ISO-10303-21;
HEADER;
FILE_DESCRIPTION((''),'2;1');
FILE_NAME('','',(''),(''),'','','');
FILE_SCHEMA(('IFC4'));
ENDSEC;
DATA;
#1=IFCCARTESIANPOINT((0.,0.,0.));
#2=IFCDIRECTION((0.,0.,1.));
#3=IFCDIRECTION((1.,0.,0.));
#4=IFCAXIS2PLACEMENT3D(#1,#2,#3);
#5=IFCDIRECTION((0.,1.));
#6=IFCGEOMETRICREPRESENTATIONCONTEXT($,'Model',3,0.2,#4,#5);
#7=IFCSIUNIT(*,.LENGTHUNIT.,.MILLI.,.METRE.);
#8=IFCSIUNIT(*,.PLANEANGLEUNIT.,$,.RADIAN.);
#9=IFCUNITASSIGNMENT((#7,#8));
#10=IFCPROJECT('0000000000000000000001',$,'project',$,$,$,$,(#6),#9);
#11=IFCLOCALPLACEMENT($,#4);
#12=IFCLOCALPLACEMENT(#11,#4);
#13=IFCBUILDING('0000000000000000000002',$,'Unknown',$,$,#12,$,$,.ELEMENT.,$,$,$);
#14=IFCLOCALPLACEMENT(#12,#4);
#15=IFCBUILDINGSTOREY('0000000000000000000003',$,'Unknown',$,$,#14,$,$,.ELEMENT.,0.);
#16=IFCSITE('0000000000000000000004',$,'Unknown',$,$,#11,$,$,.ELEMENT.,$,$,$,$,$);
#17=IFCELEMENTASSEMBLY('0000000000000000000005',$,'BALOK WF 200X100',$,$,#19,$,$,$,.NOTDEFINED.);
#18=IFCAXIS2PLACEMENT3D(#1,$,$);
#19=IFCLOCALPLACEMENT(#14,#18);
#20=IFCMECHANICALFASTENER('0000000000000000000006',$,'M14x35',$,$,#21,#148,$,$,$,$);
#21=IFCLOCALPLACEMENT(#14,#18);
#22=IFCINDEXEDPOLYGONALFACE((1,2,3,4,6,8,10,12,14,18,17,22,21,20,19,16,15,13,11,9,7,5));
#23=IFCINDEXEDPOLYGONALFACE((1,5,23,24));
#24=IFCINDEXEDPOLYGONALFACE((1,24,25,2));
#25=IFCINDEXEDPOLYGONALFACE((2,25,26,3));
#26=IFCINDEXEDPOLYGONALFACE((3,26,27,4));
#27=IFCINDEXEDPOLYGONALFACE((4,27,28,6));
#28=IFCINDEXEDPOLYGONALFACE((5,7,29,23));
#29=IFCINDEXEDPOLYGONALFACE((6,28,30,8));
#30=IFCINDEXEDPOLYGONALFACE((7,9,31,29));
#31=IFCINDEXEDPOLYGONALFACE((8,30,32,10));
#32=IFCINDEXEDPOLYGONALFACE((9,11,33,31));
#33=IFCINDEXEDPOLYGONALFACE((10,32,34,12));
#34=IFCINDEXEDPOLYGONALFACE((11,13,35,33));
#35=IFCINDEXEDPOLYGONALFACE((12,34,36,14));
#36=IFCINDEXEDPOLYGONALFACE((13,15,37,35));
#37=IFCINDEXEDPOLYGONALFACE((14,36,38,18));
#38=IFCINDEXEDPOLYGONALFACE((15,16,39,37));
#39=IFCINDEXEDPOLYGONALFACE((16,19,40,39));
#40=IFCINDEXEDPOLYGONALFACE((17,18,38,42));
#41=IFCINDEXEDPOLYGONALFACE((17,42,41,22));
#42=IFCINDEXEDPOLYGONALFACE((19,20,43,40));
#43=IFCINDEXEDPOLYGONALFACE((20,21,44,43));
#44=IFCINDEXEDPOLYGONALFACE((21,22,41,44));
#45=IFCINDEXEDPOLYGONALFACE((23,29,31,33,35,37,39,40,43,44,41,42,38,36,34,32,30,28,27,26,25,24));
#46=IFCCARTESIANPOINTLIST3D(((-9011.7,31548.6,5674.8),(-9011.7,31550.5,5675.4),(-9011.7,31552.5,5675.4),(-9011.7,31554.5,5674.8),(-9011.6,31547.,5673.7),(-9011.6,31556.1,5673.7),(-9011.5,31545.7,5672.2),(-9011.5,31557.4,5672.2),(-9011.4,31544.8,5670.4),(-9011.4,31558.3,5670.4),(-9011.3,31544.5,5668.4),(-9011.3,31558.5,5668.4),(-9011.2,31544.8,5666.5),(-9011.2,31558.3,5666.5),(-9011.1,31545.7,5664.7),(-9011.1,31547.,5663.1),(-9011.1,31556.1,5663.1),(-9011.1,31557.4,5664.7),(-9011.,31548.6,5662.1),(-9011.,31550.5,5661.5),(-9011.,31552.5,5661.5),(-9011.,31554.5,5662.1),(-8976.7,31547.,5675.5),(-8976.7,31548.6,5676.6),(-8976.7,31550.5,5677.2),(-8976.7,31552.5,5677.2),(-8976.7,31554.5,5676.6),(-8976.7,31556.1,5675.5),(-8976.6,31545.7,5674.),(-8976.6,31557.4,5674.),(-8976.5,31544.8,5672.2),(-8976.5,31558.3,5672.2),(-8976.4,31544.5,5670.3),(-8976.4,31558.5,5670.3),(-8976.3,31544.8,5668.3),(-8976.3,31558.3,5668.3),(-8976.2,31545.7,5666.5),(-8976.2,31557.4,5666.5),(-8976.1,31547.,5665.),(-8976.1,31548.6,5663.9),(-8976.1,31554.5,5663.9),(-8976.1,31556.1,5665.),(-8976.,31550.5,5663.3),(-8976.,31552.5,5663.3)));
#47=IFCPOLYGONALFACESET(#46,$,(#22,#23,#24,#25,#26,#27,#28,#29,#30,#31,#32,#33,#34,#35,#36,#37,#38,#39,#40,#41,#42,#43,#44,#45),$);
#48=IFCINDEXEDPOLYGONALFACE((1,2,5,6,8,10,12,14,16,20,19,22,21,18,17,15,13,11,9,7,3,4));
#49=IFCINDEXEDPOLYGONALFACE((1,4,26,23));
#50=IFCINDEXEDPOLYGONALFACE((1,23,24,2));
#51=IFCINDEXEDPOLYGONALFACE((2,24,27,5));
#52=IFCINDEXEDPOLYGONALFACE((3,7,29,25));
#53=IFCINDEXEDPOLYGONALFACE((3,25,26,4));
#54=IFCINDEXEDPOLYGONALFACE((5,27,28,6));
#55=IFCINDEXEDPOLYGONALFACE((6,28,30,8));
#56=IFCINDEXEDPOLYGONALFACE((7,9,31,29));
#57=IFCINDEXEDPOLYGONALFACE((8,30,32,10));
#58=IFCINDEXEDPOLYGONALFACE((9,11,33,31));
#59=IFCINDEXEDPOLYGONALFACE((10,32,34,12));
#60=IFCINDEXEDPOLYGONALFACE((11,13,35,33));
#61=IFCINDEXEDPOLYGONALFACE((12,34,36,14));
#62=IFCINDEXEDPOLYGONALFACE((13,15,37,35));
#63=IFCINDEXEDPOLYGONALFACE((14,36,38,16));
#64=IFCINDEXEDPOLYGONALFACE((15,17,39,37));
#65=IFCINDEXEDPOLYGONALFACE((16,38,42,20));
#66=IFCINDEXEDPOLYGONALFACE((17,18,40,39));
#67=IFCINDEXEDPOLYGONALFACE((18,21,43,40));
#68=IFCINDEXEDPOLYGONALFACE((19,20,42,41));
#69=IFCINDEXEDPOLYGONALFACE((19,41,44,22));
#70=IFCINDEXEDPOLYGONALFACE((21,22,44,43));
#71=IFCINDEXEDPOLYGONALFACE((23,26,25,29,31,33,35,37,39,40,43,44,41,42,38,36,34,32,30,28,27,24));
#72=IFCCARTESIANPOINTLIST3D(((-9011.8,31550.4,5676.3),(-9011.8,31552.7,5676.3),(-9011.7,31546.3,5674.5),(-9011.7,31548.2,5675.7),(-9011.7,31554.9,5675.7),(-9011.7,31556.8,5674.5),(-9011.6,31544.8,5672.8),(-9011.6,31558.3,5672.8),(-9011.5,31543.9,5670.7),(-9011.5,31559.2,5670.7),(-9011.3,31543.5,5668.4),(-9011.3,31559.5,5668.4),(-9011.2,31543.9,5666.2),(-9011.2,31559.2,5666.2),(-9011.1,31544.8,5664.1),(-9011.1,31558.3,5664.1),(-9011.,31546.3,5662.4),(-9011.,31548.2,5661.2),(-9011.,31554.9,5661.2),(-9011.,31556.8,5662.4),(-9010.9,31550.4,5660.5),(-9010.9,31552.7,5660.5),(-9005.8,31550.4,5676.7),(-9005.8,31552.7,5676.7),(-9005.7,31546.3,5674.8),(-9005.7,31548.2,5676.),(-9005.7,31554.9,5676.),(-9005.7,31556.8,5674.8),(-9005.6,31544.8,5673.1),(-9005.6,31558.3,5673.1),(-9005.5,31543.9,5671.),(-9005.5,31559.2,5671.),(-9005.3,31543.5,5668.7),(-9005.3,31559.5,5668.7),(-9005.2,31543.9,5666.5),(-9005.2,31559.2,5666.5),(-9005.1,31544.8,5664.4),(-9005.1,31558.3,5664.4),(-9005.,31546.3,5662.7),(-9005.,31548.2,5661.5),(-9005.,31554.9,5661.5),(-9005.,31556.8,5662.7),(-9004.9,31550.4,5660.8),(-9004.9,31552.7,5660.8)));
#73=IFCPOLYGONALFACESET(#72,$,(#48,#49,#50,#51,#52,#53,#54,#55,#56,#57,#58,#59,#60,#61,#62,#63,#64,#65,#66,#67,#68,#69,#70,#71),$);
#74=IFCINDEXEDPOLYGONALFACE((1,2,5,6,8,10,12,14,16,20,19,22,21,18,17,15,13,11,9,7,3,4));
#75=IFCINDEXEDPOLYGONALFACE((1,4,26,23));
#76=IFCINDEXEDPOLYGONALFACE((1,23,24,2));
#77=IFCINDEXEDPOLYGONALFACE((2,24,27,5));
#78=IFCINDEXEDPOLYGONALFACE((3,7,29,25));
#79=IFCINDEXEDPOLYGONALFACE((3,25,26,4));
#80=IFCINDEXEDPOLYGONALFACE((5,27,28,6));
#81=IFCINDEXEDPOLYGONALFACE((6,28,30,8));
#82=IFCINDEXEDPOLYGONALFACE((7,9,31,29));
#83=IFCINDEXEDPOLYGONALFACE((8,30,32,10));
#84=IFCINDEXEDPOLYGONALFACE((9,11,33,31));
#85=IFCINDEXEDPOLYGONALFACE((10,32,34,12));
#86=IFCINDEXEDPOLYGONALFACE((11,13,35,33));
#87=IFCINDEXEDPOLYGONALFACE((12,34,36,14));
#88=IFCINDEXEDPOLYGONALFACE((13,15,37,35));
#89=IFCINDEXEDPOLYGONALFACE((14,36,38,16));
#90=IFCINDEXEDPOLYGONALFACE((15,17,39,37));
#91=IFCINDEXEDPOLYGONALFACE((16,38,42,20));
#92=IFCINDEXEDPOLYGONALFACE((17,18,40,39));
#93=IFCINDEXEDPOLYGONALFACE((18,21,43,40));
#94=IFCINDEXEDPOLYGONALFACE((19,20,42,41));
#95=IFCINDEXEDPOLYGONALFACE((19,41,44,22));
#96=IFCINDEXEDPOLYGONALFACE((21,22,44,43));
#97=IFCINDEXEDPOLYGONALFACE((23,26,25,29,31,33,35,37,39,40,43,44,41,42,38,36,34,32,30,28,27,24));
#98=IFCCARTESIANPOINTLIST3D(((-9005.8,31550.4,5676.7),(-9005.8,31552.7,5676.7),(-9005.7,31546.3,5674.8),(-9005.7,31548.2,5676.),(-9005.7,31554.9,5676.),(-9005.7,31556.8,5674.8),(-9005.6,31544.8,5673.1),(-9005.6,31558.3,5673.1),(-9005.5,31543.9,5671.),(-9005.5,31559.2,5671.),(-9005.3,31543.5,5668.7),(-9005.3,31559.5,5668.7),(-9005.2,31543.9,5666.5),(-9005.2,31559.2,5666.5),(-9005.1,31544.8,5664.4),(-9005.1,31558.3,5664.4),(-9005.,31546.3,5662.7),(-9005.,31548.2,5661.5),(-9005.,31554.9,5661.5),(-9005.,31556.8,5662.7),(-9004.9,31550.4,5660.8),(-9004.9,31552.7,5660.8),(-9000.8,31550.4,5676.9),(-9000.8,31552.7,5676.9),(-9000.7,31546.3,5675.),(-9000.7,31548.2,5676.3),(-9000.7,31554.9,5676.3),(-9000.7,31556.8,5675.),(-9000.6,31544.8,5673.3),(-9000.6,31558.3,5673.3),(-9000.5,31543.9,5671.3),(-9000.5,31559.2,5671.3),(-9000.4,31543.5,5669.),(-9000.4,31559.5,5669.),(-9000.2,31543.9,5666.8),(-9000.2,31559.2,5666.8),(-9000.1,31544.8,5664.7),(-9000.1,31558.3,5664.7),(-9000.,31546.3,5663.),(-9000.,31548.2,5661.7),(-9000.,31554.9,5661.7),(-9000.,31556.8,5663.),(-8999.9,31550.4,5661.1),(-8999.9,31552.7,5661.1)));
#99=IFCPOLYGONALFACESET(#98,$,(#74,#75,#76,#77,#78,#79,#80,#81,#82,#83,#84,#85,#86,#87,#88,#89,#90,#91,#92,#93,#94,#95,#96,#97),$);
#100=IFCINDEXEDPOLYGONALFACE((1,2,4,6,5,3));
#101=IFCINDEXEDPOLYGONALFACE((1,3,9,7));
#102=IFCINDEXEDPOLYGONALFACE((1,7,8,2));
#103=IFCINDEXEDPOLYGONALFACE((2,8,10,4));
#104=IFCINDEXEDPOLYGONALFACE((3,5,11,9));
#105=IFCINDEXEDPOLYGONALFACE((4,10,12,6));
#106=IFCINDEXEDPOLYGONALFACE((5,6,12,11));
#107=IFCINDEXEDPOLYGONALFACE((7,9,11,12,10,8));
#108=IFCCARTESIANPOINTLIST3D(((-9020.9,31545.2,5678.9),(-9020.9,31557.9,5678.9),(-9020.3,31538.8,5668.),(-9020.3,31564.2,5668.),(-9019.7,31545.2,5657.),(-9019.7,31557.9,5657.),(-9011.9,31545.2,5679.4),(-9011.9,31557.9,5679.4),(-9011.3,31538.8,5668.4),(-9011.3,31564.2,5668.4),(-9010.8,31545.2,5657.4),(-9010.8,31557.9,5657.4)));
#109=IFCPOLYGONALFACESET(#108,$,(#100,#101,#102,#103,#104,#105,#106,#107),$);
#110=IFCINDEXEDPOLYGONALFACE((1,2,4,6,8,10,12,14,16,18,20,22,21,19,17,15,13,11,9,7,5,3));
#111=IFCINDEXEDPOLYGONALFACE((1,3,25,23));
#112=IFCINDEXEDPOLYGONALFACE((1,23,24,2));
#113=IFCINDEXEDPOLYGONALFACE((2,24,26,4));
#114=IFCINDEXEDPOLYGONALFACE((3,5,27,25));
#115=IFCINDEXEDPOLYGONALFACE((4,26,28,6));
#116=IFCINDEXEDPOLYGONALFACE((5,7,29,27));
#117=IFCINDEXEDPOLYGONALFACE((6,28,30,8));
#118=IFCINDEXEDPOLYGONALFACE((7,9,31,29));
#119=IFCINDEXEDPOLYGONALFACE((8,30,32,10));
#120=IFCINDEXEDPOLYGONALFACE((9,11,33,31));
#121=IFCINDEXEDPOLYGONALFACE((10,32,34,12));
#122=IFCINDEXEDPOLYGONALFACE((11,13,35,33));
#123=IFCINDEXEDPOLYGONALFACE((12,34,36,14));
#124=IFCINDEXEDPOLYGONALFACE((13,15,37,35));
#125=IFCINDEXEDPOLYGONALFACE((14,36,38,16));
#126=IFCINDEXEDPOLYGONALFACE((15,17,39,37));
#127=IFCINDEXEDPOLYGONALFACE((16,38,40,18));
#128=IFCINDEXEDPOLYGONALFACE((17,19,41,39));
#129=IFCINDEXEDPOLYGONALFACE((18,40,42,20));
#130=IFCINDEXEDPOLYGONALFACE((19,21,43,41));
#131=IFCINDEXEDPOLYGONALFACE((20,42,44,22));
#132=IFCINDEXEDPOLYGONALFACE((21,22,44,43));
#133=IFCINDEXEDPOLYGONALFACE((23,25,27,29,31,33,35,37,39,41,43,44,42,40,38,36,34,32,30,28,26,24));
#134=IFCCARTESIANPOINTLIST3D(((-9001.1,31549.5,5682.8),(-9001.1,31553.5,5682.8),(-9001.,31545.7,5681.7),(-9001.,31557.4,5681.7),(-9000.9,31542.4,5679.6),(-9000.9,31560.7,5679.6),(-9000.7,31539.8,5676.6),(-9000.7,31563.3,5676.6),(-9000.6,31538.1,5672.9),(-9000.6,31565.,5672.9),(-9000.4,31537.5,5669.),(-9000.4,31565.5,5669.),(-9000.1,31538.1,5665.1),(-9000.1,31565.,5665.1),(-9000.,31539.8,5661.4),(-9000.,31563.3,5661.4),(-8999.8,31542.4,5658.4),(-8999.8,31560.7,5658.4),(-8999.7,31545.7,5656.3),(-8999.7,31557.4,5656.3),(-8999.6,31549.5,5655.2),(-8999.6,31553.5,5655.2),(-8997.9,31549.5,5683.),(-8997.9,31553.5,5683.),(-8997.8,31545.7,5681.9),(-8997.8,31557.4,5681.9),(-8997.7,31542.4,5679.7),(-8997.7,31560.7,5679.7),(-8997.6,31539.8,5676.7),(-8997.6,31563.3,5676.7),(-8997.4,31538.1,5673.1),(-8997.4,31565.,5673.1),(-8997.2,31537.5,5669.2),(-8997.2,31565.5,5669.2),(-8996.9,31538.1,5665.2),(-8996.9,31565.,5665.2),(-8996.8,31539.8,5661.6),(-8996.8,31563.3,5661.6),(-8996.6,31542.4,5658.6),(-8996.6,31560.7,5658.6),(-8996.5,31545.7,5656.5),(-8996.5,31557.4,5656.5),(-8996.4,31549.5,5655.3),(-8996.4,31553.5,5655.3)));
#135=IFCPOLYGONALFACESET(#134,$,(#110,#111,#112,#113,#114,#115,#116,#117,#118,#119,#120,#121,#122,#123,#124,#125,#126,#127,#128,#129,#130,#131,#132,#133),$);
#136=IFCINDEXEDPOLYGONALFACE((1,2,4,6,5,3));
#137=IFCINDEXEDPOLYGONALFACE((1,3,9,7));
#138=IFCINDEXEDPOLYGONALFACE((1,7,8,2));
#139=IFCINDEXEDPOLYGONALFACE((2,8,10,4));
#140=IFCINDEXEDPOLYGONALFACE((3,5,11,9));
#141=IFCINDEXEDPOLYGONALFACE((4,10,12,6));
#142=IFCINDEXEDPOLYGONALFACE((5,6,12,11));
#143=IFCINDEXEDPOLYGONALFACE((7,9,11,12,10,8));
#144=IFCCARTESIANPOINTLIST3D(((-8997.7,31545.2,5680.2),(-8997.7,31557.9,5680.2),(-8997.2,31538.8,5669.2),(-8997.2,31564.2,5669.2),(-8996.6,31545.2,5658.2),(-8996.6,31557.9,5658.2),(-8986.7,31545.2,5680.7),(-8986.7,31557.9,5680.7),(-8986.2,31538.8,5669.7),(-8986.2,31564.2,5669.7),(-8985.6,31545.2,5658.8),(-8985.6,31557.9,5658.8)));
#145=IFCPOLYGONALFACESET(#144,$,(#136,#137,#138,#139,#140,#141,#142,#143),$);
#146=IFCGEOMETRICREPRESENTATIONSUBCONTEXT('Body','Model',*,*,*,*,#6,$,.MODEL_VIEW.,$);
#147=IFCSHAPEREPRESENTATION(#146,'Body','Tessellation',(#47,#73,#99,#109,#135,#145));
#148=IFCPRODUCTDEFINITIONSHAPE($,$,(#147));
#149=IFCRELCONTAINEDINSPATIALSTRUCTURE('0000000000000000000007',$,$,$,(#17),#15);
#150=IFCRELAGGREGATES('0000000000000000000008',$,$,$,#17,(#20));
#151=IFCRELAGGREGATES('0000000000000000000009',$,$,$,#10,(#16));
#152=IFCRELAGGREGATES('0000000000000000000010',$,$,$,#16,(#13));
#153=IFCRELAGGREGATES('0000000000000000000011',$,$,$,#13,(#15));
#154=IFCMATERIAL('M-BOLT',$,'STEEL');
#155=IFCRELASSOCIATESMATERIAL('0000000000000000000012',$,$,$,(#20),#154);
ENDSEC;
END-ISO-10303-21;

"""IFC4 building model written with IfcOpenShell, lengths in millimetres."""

from ifc_helpers import new_model, si_unit, direction, frame, origin_with_axes, place, context, subcontext, project, spatial, line, arc, indexed_curve, outline, extrude, source, transform, mapped, material, element, aggregate, save


model = new_model("IFC4")

# Units and contexts
model_context = context("Model", 3, precision=0.2, world=origin_with_axes(), true_north=direction((0.0, 1.0)))
body_context = subcontext(model_context, "Body", "Model", "MODEL_VIEW")
ifc_project = project(units=[si_unit("LENGTHUNIT", "METRE", prefix="MILLI"), si_unit("PLANEANGLEUNIT", "RADIAN")], contexts=[model_context])

# Site, building, storey
site_placement = place(None, origin_with_axes())
site = spatial("IfcSite", under=ifc_project, at=site_placement, Name="Unknown", CompositionType="ELEMENT")
building_placement = place(site_placement, origin_with_axes())
building = spatial("IfcBuilding", under=site, at=building_placement, Name="Unknown", CompositionType="ELEMENT")
storey_placement = place(building_placement, origin_with_axes())
storey = spatial("IfcBuildingStorey", under=building, at=storey_placement, Name="Unknown", CompositionType="ELEMENT", Elevation=0.0)

# Element assembly
assembly_1_placement = place(storey_placement, frame((-7044.1, 31466.5, 5721.5), z_axis=(0.0, 1.0, 0.0), x_axis=(-0.99863, 0.0, -0.052336)))
assembly_1 = element("IfcElementAssembly", 1, at=assembly_1_placement, inside=storey, Name="BALOK WF 200X100", PredefinedType="NOTDEFINED")

# Mechanical fastener
ifc_material_1 = material(Name="M-BOLT", Category="STEEL")
shared_shape_1 = source(origin_with_axes(), body_context, "Body", "SweptSolid", [
    extrude(outline(indexed_curve([(7.0, 0.0), (0.0, 7.0), (-7.0, 0.0), (0.0, -7.0)], segments=[arc(1, 2, 3), arc(3, 4, 1)])), frame((0.0, 0.0, 0.0), z_axis=(0.0, 0.0, -1.0), x_axis=(0.0, 1.0, 0.0)), (0.0, 0.0, 1.0), 35.0),
    extrude(outline(indexed_curve([(8.0, 0.0), (0.0, 8.0), (-8.0, 0.0), (0.0, -8.0)], segments=[arc(1, 2, 3), arc(3, 4, 1)])), frame((0.0, 0.0, 0.0), z_axis=(0.0, 0.0, -1.0), x_axis=(0.0, 1.0, 0.0)), (0.0, 0.0, 1.0), 6.0),
    extrude(outline(indexed_curve([(8.0, 0.0), (0.0, 8.0), (-8.0, 0.0), (0.0, -8.0)], segments=[arc(1, 2, 3), arc(3, 4, 1)])), frame((0.0, 0.0, -6.0), z_axis=(0.0, 0.0, -1.0), x_axis=(0.0, 1.0, 0.0)), (0.0, 0.0, 1.0), 5.0),
    extrude(outline(indexed_curve([(12.7, 0.0), (6.4, 11.0), (-6.4, 11.0), (-12.7, 0.0), (-6.4, -11.0), (6.4, -11.0)], segments=[line(1, 2, 3, 4, 5, 6, 1)])), frame((0.0, 0.0, 9.0), z_axis=(0.0, 0.0, -1.0), x_axis=(0.0, 1.0, 0.0)), (0.0, 0.0, 1.0), 9.0),
    extrude(outline(indexed_curve([(14.0, 0.0), (0.0, 14.0), (-14.0, 0.0), (0.0, -14.0)], segments=[arc(1, 2, 3), arc(3, 4, 1)])), frame((0.0, 0.0, -11.0), z_axis=(0.0, 0.0, -1.0), x_axis=(0.0, 1.0, 0.0)), (0.0, 0.0, 1.0), 3.2),
    extrude(outline(indexed_curve([(12.7, 0.0), (6.4, 11.0), (-6.4, 11.0), (-12.7, 0.0), (-6.4, -11.0), (6.4, -11.0)], segments=[line(1, 2, 3, 4, 5, 6, 1)])), frame((0.0, 0.0, -14.2), z_axis=(0.0, 0.0, -1.0), x_axis=(0.0, 1.0, 0.0)), (0.0, 0.0, 1.0), 11.0),
])
mechanical_fastener_1_placement = place(assembly_1_placement, frame((1967.3, 50.0, 85.0), z_axis=(1.0, 0.0, 0.000006), x_axis=(0.0, -1.0, 0.0)))
mechanical_fastener_1 = element("IfcMechanicalFastener", 2, at=mechanical_fastener_1_placement, material=ifc_material_1, Name="M14x35", context=body_context, shape_type="MappedRepresentation", body=[
    mapped(shared_shape_1, transform((0.0, 0.0, 0.0))),
])

aggregate(assembly_1, [mechanical_fastener_1])

save(model, "model.ifc")
